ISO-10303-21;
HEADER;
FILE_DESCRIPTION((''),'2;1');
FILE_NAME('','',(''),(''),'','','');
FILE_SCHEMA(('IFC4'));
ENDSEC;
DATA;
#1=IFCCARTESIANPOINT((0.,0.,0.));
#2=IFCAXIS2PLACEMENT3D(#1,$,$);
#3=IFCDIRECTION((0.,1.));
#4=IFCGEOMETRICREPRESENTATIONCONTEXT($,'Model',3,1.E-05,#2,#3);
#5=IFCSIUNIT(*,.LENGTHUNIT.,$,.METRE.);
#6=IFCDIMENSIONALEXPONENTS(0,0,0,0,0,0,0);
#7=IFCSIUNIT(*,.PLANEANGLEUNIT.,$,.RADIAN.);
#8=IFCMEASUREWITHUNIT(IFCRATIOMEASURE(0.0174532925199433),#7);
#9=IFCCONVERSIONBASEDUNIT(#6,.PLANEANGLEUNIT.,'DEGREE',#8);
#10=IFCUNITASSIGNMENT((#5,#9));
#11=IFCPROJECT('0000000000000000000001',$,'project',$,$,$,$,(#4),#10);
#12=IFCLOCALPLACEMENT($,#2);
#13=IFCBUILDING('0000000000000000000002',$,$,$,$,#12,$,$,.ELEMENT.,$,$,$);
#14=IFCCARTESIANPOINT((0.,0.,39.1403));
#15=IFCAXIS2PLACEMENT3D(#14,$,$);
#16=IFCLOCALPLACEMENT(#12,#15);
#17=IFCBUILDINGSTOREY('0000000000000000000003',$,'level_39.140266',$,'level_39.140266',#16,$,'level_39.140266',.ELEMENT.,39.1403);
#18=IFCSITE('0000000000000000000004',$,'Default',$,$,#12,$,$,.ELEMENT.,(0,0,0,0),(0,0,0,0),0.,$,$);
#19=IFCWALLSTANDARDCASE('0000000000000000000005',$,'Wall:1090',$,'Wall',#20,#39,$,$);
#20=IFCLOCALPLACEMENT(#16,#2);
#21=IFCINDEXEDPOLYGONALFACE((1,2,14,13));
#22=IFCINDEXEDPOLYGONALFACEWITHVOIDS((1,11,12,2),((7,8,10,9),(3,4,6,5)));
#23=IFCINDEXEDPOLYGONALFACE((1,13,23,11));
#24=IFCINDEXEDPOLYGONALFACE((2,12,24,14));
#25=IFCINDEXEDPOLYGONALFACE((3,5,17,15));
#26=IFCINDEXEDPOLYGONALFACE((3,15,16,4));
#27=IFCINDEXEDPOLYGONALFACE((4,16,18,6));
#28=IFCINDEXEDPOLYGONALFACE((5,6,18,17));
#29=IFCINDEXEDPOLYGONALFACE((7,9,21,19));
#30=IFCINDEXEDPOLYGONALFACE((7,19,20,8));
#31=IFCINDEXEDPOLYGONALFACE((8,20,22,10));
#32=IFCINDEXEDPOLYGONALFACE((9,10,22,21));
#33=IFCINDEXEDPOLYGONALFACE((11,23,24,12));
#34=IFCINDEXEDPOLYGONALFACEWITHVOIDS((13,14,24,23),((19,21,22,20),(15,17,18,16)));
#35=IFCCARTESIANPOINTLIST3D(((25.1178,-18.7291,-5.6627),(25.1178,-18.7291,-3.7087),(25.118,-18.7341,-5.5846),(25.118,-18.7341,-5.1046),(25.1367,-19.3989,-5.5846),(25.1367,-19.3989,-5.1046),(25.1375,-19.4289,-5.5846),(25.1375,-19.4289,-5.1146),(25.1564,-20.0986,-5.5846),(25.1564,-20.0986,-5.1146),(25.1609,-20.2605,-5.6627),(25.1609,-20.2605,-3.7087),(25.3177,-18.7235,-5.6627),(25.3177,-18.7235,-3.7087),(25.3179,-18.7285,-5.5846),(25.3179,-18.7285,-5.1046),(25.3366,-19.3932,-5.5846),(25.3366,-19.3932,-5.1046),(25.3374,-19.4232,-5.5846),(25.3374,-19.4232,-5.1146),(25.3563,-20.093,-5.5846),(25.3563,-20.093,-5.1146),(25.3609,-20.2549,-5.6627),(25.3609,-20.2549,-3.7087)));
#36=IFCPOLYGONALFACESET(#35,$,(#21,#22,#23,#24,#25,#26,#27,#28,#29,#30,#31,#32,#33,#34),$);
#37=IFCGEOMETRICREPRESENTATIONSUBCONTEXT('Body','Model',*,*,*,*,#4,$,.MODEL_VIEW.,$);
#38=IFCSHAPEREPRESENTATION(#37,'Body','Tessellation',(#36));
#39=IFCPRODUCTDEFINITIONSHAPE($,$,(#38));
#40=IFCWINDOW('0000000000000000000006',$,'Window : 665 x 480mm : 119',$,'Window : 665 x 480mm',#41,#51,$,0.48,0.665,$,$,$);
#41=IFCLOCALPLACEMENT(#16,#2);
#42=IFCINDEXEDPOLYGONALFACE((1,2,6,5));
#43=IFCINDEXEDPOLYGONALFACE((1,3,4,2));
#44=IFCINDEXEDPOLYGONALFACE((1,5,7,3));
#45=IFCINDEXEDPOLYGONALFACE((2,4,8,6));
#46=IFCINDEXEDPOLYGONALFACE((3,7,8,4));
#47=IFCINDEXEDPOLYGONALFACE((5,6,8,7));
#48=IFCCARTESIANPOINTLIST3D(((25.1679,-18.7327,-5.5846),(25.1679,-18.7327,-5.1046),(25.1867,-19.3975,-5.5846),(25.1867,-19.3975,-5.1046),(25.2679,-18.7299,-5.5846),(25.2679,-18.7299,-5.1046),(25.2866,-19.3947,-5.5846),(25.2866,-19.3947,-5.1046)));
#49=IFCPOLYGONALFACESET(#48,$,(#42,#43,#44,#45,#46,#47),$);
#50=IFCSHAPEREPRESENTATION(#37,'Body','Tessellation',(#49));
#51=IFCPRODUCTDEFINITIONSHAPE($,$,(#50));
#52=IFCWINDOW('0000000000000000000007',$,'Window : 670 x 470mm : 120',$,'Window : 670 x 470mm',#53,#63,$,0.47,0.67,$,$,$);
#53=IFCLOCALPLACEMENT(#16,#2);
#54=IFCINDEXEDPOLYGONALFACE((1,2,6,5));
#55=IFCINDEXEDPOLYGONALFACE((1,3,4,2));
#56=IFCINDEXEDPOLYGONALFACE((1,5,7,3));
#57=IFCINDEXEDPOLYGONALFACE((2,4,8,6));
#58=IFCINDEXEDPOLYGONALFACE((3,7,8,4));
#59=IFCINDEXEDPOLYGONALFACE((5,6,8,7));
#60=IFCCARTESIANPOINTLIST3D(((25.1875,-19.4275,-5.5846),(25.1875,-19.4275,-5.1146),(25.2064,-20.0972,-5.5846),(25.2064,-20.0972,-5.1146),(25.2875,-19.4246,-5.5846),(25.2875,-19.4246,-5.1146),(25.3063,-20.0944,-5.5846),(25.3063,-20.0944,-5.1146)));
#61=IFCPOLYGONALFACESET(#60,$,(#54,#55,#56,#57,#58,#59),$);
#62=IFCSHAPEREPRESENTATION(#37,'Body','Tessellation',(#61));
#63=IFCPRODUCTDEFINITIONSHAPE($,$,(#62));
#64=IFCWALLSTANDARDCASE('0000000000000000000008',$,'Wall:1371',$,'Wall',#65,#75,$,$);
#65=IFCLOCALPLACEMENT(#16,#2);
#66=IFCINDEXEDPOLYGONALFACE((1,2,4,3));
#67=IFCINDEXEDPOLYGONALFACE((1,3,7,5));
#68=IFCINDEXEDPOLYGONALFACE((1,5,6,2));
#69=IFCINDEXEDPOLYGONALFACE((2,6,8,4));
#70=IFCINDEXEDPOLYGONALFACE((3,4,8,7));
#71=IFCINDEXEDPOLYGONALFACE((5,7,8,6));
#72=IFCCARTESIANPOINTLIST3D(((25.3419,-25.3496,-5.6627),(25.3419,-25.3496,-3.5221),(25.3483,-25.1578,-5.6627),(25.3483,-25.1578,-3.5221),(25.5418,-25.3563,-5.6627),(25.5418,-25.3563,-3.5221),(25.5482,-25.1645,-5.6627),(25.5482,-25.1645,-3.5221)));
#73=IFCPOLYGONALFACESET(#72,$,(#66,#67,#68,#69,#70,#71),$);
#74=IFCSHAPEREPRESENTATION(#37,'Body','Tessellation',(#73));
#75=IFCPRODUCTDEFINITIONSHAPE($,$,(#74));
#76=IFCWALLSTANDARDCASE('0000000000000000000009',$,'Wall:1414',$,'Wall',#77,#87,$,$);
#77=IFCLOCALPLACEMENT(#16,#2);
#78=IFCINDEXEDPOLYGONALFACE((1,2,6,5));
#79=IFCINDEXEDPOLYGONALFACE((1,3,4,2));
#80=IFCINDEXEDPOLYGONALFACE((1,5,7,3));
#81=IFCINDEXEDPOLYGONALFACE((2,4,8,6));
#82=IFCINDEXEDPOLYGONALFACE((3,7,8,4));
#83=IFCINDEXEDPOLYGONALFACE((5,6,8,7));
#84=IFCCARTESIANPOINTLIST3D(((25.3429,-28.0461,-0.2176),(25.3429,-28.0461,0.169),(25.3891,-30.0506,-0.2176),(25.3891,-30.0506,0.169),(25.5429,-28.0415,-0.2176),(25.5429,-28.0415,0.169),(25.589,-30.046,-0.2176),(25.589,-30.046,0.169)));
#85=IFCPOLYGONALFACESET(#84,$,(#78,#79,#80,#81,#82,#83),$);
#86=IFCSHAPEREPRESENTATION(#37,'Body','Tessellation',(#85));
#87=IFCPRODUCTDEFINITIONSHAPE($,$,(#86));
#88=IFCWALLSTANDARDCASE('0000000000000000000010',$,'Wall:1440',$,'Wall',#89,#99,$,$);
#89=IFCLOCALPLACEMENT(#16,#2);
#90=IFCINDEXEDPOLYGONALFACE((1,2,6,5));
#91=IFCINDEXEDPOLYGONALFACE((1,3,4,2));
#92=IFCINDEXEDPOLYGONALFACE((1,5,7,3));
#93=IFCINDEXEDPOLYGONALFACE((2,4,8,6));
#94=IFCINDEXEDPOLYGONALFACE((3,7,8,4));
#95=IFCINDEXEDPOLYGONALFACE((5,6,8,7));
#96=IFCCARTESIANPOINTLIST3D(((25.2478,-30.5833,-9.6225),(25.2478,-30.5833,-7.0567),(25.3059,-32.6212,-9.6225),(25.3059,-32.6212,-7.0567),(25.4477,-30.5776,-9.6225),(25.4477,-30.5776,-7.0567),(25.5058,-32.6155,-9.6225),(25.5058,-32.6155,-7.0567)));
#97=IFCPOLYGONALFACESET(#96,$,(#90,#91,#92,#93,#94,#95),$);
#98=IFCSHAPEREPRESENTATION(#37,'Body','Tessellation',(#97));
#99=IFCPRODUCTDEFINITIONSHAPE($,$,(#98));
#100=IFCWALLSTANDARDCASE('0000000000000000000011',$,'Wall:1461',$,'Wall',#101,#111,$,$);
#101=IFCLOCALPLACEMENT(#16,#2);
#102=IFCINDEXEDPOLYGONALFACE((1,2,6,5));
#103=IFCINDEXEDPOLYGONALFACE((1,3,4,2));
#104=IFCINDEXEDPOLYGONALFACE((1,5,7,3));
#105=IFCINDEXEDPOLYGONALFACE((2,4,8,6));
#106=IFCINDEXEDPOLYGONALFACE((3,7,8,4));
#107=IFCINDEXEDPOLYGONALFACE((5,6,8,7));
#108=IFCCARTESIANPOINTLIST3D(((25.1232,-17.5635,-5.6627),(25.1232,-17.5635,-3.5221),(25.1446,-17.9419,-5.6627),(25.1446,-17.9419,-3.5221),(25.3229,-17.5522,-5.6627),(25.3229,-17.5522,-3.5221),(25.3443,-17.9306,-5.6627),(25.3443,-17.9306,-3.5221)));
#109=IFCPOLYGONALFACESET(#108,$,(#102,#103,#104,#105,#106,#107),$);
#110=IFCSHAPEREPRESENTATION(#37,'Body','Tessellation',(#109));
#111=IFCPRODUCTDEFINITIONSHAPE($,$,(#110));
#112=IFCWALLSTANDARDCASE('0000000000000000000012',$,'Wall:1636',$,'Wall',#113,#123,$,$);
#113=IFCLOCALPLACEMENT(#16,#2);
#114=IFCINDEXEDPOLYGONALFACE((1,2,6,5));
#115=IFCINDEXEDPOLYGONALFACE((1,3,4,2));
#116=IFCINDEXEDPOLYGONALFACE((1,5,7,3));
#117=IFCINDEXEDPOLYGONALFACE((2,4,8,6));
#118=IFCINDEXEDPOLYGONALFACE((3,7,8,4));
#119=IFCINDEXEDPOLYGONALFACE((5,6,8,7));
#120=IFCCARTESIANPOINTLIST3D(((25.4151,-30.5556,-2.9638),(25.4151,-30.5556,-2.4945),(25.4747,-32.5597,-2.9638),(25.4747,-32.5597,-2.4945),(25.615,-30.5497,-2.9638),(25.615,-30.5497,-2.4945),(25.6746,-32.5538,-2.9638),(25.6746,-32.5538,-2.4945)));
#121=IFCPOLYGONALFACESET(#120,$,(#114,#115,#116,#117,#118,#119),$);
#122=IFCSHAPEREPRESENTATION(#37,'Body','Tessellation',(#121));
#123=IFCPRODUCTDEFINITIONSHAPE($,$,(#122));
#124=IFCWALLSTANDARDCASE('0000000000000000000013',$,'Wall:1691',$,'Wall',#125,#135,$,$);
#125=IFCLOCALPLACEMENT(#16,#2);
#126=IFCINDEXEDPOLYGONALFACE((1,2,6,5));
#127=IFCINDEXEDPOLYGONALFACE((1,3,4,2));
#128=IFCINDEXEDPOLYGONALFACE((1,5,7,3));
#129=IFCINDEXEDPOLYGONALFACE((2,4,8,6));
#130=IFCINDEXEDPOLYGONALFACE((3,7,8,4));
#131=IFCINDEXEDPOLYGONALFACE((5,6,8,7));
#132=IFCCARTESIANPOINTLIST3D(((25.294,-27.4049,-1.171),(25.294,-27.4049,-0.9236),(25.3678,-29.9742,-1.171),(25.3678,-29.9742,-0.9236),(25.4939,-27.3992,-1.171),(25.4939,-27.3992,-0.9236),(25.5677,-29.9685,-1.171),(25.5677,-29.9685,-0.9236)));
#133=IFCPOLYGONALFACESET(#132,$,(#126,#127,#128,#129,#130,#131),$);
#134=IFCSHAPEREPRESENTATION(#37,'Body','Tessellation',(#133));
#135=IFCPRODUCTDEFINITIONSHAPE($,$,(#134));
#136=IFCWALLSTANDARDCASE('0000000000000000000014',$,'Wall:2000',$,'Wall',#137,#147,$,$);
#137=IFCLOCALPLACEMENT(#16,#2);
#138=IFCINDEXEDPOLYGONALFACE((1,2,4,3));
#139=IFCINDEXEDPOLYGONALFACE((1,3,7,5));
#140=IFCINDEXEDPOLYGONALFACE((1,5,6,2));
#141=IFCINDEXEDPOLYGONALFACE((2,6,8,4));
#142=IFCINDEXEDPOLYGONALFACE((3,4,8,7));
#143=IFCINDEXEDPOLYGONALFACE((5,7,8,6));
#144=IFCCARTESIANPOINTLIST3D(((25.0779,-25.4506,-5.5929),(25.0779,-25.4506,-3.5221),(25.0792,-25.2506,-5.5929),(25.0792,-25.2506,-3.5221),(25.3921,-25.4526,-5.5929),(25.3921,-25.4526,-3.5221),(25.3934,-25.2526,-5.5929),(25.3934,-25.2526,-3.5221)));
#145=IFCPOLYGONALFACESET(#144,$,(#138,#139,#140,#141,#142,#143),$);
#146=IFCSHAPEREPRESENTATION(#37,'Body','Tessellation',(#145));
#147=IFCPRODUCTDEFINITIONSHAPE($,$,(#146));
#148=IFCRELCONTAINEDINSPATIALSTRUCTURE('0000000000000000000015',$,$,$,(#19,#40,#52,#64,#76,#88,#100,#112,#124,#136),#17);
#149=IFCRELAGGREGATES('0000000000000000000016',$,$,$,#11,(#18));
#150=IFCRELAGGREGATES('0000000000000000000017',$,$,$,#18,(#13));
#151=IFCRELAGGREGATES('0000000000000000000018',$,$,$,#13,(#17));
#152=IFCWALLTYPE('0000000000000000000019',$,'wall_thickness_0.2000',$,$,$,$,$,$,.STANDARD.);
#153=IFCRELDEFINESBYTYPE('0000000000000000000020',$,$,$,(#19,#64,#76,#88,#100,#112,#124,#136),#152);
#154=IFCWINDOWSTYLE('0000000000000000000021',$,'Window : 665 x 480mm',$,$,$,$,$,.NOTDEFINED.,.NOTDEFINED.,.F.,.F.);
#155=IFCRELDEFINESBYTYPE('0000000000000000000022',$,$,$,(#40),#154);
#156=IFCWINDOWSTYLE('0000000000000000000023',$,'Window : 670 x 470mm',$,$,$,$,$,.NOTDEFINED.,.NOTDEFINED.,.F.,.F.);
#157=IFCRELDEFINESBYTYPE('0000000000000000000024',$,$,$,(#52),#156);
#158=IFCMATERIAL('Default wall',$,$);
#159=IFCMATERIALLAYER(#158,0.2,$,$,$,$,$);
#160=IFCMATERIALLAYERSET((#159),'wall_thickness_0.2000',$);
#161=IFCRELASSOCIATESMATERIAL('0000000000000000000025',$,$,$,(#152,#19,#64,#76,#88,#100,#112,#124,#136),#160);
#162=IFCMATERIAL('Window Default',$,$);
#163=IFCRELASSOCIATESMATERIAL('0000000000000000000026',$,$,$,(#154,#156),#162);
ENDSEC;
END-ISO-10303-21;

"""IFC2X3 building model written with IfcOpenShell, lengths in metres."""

from ifc_helpers import new_model, entity, si_unit, converted_unit, direction, frame, frame_2d, origin, origin_2d_with_axis, place, context, subcontext, project, spatial, polyline, rectangle, outline, extrude, source, transform, mapped, material, layer, layer_set, layer_usage, type_object, type_shapes, element, fill, save


model = new_model("IFC2X3")

# Units and contexts
model_context = context("Model", 3, precision=1e-05, world=origin(), true_north=direction((0.0, 1.0)))
body_context = subcontext(model_context, "Body", "Model", "MODEL_VIEW")
ifc_project = project(units=[si_unit("LENGTHUNIT", "METRE"), converted_unit("PLANEANGLEUNIT", "DEGREE", entity("IfcRatioMeasure", 0.0174532925199433), si_unit("PLANEANGLEUNIT", "RADIAN"), dimensions=[0, 0, 0, 0, 0, 0, 0])], contexts=[model_context])

# Site, building, storey
placement_1 = place(None, origin())
site = spatial("IfcSite", under=ifc_project, at=placement_1, Name="Default", CompositionType="ELEMENT", RefLatitude=(0, 0, 0, 0), RefLongitude=(0, 0, 0, 0), RefElevation=0.0)
building = spatial("IfcBuilding", under=site, at=placement_1, CompositionType="ELEMENT")
storey_placement = place(placement_1, frame((0.0, 0.0, 39.1403)))
storey = spatial("IfcBuildingStorey", under=building, at=storey_placement, Name="level_39.140266", ObjectType="level_39.140266", LongName="level_39.140266", CompositionType="ELEMENT", Elevation=39.1403)

# Shared definitions
ifc_material_1 = material(Name="Default wall")
ifc_layer = layer(ifc_material_1, 0.2)
ifc_layer_set = layer_set([ifc_layer], Name="wall_thickness_0.2000")
ifc_layer_usage = layer_usage(ifc_layer_set, "AXIS2", "POSITIVE", -0.1)
wall_type = type_object("IfcWallType", Name="wall_thickness_0.2000", PredefinedType="STANDARD", material=ifc_layer_set)
ifc_material_2 = material(Name="Window Default")

# Wall, openings, windows
placement_2 = place(placement_1, frame((0.0, 0.0, 33.4776)))
wall_1_placement = place(placement_2, frame((25.2178, -18.7263, 0.0), z_axis=(0.0, 0.0, 1.0), x_axis=(0.028156, -0.999604, 0.0)))
wall_1 = element("IfcWallStandardCase", 1, at=wall_1_placement, inside=storey, type_object=wall_type, material=ifc_layer_usage, Name="Wall:1090", ObjectType="Wall", context=body_context, shape_type="SweptSolid", body=[
    extrude(outline(polyline([(1.532, -0.1), (1.532, 0.1), (0.0, 0.1), (0.0, -0.1), (1.532, -0.1)])), origin(), (0.0, 0.0, 1.0), 1.9541),
])
opening_1_placement = place(wall_1_placement, frame((0.005, -0.1, 0.0782)))
opening_1 = element("IfcOpeningElement", 2, at=opening_1_placement, cuts=wall_1, ObjectType="Opening", context=body_context, shape_type="SweptSolid", body=[
    extrude(rectangle(XDim=0.665, YDim=0.48, at=frame_2d((0.24, 0.3325), x_axis=(0.0, 1.0))), frame((0.0, 0.0, 0.0), z_axis=(0.0, 1.0, 0.0), x_axis=(0.0, 0.0, 1.0)), (0.0, 0.0, 1.0), 0.2),
])
opening_2_placement = place(wall_1_placement, frame((0.7, -0.1, 0.0782)))
opening_2 = element("IfcOpeningElement", 3, at=opening_2_placement, cuts=wall_1, ObjectType="Opening", context=body_context, shape_type="SweptSolid", body=[
    extrude(rectangle(XDim=0.67, YDim=0.47, at=frame_2d((0.235, 0.335), x_axis=(0.0, 1.0))), frame((0.0, 0.0, 0.0), z_axis=(0.0, 1.0, 0.0), x_axis=(0.0, 0.0, 1.0)), (0.0, 0.0, 1.0), 0.2),
])
window_style_1 = type_object("IfcWindowStyle", Name="Window : 665 x 480mm", ConstructionType="NOTDEFINED", OperationType="NOTDEFINED", ParameterTakesPrecedence=False, Sizeable=False, material=ifc_material_2)
shared_shape_1 = source(origin(), body_context, "Body", "SweptSolid", [
    extrude(rectangle(XDim=0.1, YDim=0.665, at=origin_2d_with_axis()), frame((0.3325, 0.1, 0.0), z_axis=(0.0, 0.0, 1.0), x_axis=(0.0, 1.0, 0.0)), (0.0, 0.0, 1.0), 0.48),
])
type_shapes(window_style_1, [shared_shape_1])
window_1_placement = place(opening_1_placement, origin())
window_1 = element("IfcWindow", 4, at=window_1_placement, inside=storey, type_object=window_style_1, Name="Window : 665 x 480mm : 119", ObjectType="Window : 665 x 480mm", OverallHeight=0.48, OverallWidth=0.665, context=body_context, shape_type="MappedRepresentation", body=[
    mapped(shared_shape_1, transform((0.0, 0.0, 0.0), scale=1.0)),
])
fill(opening_1, window_1)
window_style_2 = type_object("IfcWindowStyle", Name="Window : 670 x 470mm", ConstructionType="NOTDEFINED", OperationType="NOTDEFINED", ParameterTakesPrecedence=False, Sizeable=False, material=ifc_material_2)
shared_shape_2 = source(origin(), body_context, "Body", "SweptSolid", [
    extrude(rectangle(XDim=0.1, YDim=0.67, at=origin_2d_with_axis()), frame((0.335, 0.1, 0.0), z_axis=(0.0, 0.0, 1.0), x_axis=(0.0, 1.0, 0.0)), (0.0, 0.0, 1.0), 0.47),
])
type_shapes(window_style_2, [shared_shape_2])
window_2_placement = place(opening_2_placement, origin())
window_2 = element("IfcWindow", 5, at=window_2_placement, inside=storey, type_object=window_style_2, Name="Window : 670 x 470mm : 120", ObjectType="Window : 670 x 470mm", OverallHeight=0.47, OverallWidth=0.67, context=body_context, shape_type="MappedRepresentation", body=[
    mapped(shared_shape_2, transform((0.0, 0.0, 0.0), scale=1.0)),
])
fill(opening_2, window_2)

# Walls
placement_3 = place(placement_1, frame((0.0, 0.0, 33.4776)))
wall_2_placement = place(placement_3, frame((25.4418, -25.353, 0.0), z_axis=(0.0, 0.0, 1.0), x_axis=(0.03357, 0.999436, 0.0)))
element("IfcWallStandardCase", 6, at=wall_2_placement, inside=storey, type_object=wall_type, material=ifc_layer_usage, Name="Wall:1371", ObjectType="Wall", context=body_context, shape_type="SweptSolid", body=[
    extrude(outline(polyline([(0.1919, -0.1), (0.1919, 0.1), (0.0, 0.1), (0.0, -0.1), (0.1919, -0.1)])), origin(), (0.0, 0.0, 1.0), 2.1406),
])
placement_4 = place(placement_1, frame((0.0, 0.0, 38.9227)))
wall_3_placement = place(placement_4, frame((25.4429, -28.0438, 0.0), z_axis=(0.0, 0.0, 1.0), x_axis=(0.023007, -0.999735, 0.0)))
element("IfcWallStandardCase", 7, at=wall_3_placement, inside=storey, type_object=wall_type, material=ifc_layer_usage, Name="Wall:1414", ObjectType="Wall", context=body_context, shape_type="SweptSolid", body=[
    extrude(outline(polyline([(2.005, -0.1), (2.005, 0.1), (0.0, 0.1), (0.0, -0.1), (2.005, -0.1)])), origin(), (0.0, 0.0, 1.0), 0.3867),
])
placement_5 = place(placement_1, frame((0.0, 0.0, 29.5178)))
wall_4_placement = place(placement_5, frame((25.3477, -30.5805, 0.0), z_axis=(0.0, 0.0, 1.0), x_axis=(0.028488, -0.999594, 0.0)))
element("IfcWallStandardCase", 8, at=wall_4_placement, inside=storey, type_object=wall_type, material=ifc_layer_usage, Name="Wall:1440", ObjectType="Wall", context=body_context, shape_type="SweptSolid", body=[
    extrude(outline(polyline([(2.0387, -0.1), (2.0387, 0.1), (0.0, 0.1), (0.0, -0.1), (2.0387, -0.1)])), origin(), (0.0, 0.0, 1.0), 2.5658),
])
placement_6 = place(placement_1, frame((0.0, 0.0, 33.4776)))
wall_5_placement = place(placement_6, frame((25.2445, -17.9362, 0.0), z_axis=(0.0, 0.0, 1.0), x_axis=(-0.056657, 0.998394, 0.0)))
element("IfcWallStandardCase", 9, at=wall_5_placement, inside=storey, type_object=wall_type, material=ifc_layer_usage, Name="Wall:1461", ObjectType="Wall", context=body_context, shape_type="SweptSolid", body=[
    extrude(outline(polyline([(0.379, -0.1), (0.379, 0.1), (0.0, 0.1), (0.0, -0.1), (0.379, -0.1)])), origin(), (0.0, 0.0, 1.0), 2.1406),
])
placement_7 = place(placement_1, frame((0.0, 0.0, 36.1765)))
wall_6_placement = place(placement_7, frame((25.5151, -30.5526, 0.0), z_axis=(0.0, 0.0, 1.0), x_axis=(0.029711, -0.999559, 0.0)))
element("IfcWallStandardCase", 10, at=wall_6_placement, inside=storey, type_object=wall_type, material=ifc_layer_usage, Name="Wall:1636", ObjectType="Wall", context=body_context, shape_type="SweptSolid", body=[
    extrude(outline(polyline([(2.005, -0.1), (2.005, 0.1), (0.0, 0.1), (0.0, -0.1), (2.005, -0.1)])), origin(), (0.0, 0.0, 1.0), 0.4693),
])
placement_8 = place(placement_1, frame((0.0, 0.0, 37.9693)))
wall_7_placement = place(placement_8, frame((25.394, -27.402, 0.0), z_axis=(0.0, 0.0, 1.0), x_axis=(0.0287, -0.999588, 0.0)))
element("IfcWallStandardCase", 11, at=wall_7_placement, inside=storey, type_object=wall_type, material=ifc_layer_usage, Name="Wall:1691", ObjectType="Wall", context=body_context, shape_type="SweptSolid", body=[
    extrude(outline(polyline([(2.5704, -0.1), (2.5704, 0.1), (0.0, 0.1), (0.0, -0.1), (2.5704, -0.1)])), origin(), (0.0, 0.0, 1.0), 0.2474),
])
placement_9 = place(placement_1, frame((0.0, 0.0, 33.5474)))
wall_8_placement = place(placement_9, frame((25.3927, -25.3526, 0.0), z_axis=(0.0, 0.0, 1.0), x_axis=(-0.999979, 0.006539, 0.0)))
element("IfcWallStandardCase", 12, at=wall_8_placement, inside=storey, type_object=wall_type, material=ifc_layer_usage, Name="Wall:2000", ObjectType="Wall", context=body_context, shape_type="SweptSolid", body=[
    extrude(outline(polyline([(0.3142, -0.1), (0.3142, 0.1), (0.0, 0.1), (0.0, -0.1), (0.3142, -0.1)])), origin(), (0.0, 0.0, 1.0), 2.0708),
])

save(model, "model.ifc")
